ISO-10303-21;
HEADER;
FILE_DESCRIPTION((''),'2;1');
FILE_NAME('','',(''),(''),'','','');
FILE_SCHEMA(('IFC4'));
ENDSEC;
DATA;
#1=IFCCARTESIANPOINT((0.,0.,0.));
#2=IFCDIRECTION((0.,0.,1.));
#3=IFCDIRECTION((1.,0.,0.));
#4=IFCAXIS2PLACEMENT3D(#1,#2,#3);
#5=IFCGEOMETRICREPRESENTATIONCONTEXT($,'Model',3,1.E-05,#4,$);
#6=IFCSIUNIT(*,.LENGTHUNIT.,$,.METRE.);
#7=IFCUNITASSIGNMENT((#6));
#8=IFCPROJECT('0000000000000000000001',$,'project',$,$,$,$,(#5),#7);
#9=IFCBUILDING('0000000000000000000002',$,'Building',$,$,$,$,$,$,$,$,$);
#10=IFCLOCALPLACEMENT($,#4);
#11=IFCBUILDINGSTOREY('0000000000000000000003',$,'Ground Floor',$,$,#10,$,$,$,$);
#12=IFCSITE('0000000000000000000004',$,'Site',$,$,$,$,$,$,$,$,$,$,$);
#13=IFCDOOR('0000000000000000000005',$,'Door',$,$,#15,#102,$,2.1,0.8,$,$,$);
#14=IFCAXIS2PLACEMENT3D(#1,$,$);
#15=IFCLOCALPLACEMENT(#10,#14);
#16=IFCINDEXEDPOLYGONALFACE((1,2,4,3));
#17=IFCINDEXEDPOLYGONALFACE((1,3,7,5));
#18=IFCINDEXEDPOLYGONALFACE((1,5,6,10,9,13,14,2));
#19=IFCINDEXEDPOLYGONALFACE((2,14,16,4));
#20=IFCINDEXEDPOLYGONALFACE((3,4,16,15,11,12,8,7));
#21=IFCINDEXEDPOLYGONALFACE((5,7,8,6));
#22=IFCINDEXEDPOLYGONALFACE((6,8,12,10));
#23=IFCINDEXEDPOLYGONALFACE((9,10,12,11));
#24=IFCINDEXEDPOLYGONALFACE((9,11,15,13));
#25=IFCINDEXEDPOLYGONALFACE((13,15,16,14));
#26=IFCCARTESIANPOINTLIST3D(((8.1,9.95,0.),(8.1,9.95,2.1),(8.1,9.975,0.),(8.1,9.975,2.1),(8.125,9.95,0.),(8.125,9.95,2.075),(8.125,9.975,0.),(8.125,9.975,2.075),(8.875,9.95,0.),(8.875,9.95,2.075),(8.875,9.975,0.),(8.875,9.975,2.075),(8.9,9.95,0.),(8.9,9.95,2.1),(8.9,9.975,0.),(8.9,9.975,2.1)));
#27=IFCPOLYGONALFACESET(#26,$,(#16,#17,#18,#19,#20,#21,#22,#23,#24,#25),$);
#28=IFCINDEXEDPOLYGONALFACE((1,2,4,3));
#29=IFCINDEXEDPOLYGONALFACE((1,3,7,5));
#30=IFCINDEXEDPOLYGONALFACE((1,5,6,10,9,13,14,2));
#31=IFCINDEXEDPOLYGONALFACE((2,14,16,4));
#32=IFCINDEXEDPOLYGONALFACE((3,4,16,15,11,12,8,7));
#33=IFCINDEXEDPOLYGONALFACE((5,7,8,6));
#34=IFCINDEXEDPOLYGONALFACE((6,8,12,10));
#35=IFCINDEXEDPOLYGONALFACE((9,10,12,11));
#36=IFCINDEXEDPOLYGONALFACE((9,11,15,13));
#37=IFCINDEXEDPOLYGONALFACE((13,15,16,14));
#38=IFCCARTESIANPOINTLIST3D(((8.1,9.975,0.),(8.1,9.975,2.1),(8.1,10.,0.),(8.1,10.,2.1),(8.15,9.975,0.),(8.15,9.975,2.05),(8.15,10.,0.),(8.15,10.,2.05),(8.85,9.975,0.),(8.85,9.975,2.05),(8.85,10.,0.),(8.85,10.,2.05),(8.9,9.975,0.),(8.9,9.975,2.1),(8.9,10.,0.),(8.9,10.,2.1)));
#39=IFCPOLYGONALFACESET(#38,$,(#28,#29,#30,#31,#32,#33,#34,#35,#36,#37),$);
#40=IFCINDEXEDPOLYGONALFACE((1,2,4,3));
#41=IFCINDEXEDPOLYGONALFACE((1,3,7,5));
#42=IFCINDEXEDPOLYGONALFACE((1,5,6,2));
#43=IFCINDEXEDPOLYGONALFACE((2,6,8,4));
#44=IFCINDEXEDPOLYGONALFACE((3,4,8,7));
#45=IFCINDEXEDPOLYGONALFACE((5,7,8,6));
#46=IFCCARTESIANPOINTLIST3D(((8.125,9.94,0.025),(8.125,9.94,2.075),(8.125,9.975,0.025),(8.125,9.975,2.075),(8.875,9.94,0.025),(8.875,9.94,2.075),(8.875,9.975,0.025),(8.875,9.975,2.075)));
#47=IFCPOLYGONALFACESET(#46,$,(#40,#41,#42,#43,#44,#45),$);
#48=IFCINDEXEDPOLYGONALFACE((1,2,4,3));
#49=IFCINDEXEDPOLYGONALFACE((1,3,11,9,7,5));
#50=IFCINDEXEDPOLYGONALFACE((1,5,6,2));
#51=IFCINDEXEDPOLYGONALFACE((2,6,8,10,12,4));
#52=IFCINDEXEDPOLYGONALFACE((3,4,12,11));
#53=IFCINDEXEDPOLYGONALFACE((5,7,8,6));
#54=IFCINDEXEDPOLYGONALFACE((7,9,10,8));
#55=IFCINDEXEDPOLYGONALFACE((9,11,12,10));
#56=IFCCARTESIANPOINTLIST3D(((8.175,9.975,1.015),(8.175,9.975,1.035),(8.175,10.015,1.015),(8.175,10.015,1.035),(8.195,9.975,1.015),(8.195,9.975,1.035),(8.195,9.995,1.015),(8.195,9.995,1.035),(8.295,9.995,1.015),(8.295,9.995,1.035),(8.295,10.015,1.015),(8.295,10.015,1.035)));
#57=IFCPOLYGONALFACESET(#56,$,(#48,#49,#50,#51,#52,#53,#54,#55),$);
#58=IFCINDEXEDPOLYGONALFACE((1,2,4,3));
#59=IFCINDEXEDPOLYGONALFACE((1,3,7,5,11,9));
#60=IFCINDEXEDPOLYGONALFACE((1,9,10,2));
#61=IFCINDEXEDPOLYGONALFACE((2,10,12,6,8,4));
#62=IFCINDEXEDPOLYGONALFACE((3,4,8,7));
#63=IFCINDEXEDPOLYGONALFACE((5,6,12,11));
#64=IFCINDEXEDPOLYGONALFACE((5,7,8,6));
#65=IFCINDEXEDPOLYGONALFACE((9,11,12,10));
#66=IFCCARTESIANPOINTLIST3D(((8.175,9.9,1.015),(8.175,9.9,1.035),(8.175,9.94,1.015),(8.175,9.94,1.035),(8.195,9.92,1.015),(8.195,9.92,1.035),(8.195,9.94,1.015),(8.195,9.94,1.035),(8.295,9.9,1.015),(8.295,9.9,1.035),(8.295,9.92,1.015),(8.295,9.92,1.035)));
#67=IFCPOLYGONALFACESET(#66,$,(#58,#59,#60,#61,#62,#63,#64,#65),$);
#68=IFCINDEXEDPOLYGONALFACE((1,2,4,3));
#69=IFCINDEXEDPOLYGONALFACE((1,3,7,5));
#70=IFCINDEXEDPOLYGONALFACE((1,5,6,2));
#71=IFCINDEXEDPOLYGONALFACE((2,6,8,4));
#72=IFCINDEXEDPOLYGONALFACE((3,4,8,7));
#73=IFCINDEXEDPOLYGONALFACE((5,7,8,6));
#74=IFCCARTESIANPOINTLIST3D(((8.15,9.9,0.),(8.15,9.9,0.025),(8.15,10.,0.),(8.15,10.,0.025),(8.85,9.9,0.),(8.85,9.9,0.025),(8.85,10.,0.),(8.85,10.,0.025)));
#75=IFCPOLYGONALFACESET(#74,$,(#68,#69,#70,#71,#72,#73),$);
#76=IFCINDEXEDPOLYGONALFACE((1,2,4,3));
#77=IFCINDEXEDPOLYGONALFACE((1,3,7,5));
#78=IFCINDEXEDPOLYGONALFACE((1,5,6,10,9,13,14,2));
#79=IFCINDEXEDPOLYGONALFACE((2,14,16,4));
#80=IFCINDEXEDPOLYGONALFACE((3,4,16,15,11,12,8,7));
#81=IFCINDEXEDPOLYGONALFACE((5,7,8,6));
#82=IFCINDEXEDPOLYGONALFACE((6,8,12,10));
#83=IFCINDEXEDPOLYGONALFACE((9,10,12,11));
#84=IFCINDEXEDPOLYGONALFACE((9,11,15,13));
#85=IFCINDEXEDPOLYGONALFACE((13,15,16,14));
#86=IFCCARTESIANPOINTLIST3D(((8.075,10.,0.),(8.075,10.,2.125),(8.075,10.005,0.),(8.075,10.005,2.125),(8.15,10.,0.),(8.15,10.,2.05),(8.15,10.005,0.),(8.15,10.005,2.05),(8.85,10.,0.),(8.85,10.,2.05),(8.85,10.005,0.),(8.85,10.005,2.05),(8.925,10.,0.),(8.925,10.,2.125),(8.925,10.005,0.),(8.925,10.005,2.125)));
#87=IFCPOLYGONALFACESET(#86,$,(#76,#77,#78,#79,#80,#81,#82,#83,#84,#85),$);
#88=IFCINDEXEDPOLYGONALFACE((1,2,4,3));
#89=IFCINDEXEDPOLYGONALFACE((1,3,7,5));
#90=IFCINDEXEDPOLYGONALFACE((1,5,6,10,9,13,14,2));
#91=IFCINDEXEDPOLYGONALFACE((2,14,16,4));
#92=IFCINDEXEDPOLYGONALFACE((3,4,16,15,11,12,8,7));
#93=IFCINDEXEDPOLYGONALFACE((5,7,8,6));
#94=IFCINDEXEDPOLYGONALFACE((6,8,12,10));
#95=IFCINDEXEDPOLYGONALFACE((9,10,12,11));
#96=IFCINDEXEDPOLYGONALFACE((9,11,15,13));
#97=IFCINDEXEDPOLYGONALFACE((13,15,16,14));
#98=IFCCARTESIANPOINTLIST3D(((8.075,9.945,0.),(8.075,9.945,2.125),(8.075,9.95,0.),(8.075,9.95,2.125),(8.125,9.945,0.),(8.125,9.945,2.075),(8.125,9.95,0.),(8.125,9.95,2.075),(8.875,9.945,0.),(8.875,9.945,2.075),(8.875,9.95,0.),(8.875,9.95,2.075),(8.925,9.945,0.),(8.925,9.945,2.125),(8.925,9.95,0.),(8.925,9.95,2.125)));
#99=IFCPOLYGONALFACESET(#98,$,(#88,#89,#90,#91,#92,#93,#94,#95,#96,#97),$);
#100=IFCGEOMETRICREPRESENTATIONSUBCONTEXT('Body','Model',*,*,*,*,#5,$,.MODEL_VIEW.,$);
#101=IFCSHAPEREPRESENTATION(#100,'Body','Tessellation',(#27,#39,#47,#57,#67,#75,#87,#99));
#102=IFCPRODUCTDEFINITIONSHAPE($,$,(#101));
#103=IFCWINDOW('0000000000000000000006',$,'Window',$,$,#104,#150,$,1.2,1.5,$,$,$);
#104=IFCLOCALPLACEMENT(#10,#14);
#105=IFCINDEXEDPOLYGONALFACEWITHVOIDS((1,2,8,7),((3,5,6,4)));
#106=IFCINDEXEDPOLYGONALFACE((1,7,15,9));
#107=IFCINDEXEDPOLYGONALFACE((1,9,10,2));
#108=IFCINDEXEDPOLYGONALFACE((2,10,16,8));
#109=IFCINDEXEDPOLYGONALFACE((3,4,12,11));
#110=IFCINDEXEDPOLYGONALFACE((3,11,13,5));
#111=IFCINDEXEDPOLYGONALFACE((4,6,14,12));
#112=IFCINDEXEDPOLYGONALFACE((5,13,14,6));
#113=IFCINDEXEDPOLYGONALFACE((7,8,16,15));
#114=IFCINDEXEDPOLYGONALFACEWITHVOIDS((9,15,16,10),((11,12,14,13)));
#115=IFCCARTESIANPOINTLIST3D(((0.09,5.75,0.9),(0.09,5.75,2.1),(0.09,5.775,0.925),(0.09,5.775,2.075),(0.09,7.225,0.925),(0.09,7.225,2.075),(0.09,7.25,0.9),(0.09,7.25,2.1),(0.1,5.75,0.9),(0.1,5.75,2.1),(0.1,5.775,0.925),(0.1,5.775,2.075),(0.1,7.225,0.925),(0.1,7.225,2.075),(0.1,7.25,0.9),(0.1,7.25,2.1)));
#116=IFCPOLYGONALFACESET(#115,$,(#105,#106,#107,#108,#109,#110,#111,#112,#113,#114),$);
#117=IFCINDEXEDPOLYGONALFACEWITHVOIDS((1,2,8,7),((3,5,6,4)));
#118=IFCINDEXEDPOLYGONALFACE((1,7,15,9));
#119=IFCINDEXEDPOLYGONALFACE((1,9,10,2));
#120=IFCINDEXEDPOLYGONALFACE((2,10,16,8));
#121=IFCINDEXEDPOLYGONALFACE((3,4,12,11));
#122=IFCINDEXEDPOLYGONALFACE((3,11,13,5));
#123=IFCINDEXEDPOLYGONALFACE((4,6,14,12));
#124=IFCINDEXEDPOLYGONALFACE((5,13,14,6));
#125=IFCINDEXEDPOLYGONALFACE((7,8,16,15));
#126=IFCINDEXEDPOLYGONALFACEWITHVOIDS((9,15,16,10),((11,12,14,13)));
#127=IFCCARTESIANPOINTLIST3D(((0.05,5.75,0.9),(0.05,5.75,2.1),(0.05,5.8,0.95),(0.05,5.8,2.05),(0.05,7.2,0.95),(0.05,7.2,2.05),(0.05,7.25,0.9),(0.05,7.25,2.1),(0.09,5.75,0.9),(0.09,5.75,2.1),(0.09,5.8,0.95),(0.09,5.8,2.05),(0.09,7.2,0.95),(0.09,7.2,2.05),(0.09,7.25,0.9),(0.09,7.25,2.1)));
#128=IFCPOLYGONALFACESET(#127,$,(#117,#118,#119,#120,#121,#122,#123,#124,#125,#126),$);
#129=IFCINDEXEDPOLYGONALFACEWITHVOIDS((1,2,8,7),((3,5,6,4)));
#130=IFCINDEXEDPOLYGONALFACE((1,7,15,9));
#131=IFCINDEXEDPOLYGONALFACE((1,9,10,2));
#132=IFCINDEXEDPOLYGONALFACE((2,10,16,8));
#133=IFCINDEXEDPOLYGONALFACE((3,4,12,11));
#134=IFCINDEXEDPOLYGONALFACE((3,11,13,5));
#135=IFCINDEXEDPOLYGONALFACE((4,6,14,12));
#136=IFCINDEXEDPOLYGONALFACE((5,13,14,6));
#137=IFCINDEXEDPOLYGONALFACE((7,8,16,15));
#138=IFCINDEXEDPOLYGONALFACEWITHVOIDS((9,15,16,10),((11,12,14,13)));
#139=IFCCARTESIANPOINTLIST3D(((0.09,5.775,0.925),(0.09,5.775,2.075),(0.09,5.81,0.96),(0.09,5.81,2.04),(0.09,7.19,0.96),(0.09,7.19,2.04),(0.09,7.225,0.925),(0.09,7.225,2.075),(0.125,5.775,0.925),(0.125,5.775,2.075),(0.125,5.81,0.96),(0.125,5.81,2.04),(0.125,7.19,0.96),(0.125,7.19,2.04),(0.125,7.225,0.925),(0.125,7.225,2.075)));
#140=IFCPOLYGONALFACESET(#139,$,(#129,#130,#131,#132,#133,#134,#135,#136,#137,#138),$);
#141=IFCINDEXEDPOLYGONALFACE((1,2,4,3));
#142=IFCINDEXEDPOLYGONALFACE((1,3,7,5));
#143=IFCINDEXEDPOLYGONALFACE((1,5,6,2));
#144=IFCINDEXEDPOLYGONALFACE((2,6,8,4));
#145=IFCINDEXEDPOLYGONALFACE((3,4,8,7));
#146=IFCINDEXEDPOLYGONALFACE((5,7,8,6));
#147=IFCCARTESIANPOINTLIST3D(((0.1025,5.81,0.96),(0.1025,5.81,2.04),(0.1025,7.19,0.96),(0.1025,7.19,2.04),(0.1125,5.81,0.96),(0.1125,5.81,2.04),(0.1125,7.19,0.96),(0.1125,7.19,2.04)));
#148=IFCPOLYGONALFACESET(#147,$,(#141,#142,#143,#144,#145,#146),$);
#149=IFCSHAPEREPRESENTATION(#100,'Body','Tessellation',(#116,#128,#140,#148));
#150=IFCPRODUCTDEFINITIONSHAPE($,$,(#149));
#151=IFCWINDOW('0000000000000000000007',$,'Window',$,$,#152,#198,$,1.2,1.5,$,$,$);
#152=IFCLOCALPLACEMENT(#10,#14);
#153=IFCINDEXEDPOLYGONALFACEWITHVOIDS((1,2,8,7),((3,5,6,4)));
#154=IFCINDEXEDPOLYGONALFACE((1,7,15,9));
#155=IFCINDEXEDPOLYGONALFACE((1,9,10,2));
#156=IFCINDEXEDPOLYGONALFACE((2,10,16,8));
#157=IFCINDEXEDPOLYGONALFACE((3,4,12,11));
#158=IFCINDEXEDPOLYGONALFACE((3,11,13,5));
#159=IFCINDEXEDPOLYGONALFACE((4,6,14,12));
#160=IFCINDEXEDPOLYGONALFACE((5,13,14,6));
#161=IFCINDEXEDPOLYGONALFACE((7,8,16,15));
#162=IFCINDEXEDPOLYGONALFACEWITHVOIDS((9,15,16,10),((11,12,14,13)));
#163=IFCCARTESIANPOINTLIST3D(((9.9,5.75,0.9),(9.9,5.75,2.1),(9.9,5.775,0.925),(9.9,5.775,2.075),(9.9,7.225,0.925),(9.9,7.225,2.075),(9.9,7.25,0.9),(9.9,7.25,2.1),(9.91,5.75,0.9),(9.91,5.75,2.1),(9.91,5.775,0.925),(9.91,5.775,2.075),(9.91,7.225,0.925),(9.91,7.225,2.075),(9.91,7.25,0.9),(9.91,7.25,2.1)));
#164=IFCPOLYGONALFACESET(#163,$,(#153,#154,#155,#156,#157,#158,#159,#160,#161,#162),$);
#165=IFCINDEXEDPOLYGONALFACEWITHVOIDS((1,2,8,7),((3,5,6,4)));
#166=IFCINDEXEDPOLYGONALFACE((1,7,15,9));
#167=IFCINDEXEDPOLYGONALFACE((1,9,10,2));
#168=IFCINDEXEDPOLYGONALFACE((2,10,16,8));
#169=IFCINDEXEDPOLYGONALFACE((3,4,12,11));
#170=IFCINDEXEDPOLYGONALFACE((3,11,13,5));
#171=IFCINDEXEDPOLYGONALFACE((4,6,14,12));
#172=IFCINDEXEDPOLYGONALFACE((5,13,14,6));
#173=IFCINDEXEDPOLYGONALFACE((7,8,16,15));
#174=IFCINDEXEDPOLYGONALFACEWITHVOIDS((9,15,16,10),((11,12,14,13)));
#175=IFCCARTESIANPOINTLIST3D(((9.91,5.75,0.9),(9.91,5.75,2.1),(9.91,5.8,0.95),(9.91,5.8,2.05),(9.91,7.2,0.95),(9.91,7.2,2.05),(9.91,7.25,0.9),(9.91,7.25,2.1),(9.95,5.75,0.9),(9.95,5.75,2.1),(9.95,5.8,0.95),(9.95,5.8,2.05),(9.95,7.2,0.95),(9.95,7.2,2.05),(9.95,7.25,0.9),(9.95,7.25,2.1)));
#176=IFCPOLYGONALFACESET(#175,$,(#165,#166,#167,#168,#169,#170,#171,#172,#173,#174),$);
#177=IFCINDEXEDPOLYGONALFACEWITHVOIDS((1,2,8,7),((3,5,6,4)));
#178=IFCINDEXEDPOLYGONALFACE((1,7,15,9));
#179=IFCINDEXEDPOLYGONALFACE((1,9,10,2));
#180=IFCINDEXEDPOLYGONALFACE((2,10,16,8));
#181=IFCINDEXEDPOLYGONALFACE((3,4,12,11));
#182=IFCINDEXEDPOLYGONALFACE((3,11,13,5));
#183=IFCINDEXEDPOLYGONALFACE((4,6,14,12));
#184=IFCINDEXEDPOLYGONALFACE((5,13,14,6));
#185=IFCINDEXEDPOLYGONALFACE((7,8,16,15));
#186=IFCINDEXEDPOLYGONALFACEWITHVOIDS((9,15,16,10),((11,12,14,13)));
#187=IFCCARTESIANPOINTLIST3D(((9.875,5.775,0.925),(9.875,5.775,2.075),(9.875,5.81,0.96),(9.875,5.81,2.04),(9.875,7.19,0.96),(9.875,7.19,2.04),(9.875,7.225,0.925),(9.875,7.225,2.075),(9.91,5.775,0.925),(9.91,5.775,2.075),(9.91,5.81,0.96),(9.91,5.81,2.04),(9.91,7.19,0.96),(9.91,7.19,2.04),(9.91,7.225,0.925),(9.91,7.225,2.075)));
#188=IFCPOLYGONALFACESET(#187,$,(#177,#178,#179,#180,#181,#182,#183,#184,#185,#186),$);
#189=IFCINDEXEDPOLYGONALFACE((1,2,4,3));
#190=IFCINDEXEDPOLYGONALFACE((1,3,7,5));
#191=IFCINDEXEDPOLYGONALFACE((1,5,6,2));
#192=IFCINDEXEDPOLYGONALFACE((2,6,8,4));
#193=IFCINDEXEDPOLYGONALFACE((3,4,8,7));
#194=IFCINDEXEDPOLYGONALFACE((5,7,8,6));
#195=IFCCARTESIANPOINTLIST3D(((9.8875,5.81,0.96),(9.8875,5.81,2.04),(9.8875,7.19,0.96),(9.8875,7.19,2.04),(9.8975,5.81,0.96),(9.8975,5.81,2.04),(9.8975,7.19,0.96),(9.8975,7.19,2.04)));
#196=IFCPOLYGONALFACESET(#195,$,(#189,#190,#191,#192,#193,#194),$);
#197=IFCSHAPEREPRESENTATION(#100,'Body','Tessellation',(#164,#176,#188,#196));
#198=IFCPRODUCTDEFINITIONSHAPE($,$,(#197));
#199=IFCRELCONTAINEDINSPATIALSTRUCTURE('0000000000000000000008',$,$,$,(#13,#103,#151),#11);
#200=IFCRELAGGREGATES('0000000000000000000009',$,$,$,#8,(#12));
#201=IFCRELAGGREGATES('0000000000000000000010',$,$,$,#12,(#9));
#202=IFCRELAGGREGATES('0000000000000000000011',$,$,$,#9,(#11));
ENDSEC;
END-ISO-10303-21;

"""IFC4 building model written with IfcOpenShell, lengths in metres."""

from ifc_helpers import new_model, si_unit, frame, origin_with_axes, place, context, subcontext, project, spatial, line, indexed_curve, outline, extrude, element, save


model = new_model("IFC4")

# Units and contexts
model_context = context("Model", 3, precision=1e-05, world=origin_with_axes())
body_context = subcontext(model_context, "Body", "Model", "MODEL_VIEW")
ifc_project = project(units=[si_unit("LENGTHUNIT", "METRE")], contexts=[model_context])

# Site, building, storey
site = spatial("IfcSite", under=ifc_project, Name="Site")
building = spatial("IfcBuilding", under=site, Name="Building")
storey_placement = place(None, origin_with_axes())
storey = spatial("IfcBuildingStorey", under=building, at=storey_placement, Name="Ground Floor")

# Door
door_1_placement = place(storey_placement, frame((8.9, 10.0, 0.0), z_axis=(0.0, 0.0, 1.0), x_axis=(-1.0, 0.0, 0.0)))
element("IfcDoor", 1, at=door_1_placement, inside=storey, Name="Door", OverallHeight=2.1, OverallWidth=0.8, context=body_context, shape_type="SweptSolid", body=[
    extrude(outline(indexed_curve([(0.0, 0.0), (0.0, 2.1), (0.8, 2.1), (0.8, 0.0), (0.775, 0.0), (0.775, 2.075), (0.025, 2.075), (0.025, 0.0)], segments=[line(1, 2, 3, 4, 5, 6, 7, 8, 1)])), frame((0.0, 0.025, 0.0), z_axis=(0.0, -1.0, 0.0), x_axis=(1.0, 0.0, 0.0)), (0.0, 0.0, -1.0), 0.025),
    extrude(outline(indexed_curve([(0.0, 0.0), (0.0, 2.1), (0.8, 2.1), (0.8, 0.0), (0.75, 0.0), (0.75, 2.05), (0.05, 2.05), (0.05, 0.0)], segments=[line(1, 2, 3, 4, 5, 6, 7, 8, 1)])), frame((0.0, 0.0, 0.0), z_axis=(0.0, -1.0, 0.0), x_axis=(1.0, 0.0, 0.0)), (0.0, 0.0, -1.0), 0.025),
    extrude(outline(indexed_curve([(0.0, 0.0), (0.75, 0.0), (0.75, 0.035), (0.0, 0.035)], segments=[line(1, 2, 3, 4, 1)])), frame((0.025, 0.025, 0.025), z_axis=(0.0, 0.0, 1.0), x_axis=(1.0, 0.0, 0.0)), (0.0, 0.0, 1.0), 2.05),
    extrude(outline(indexed_curve([(0.0, 0.0), (0.0, -0.04), (-0.12, -0.04), (-0.12, -0.02), (-0.02, -0.02), (-0.02, 0.0)], segments=[line(1, 2, 3, 4, 5, 6, 1)])), frame((0.725, 0.025, 1.015), z_axis=(0.0, 0.0, 1.0), x_axis=(1.0, 0.0, 0.0)), (0.0, 0.0, 1.0), 0.02),
    extrude(outline(indexed_curve([(0.0, 0.0), (0.0, 0.04), (-0.12, 0.04), (-0.12, 0.02), (-0.02, 0.02), (-0.02, 0.0)], segments=[line(1, 2, 3, 4, 5, 6, 1)])), frame((0.725, 0.06, 1.015), z_axis=(0.0, 0.0, 1.0), x_axis=(1.0, 0.0, 0.0)), (0.0, 0.0, 1.0), 0.02),
    extrude(outline(indexed_curve([(0.0, 0.0), (0.7, 0.0), (0.7, 0.1), (0.0, 0.1)], segments=[line(1, 2, 3, 4, 1)])), frame((0.05, 0.0, 0.0), z_axis=(0.0, 0.0, 1.0), x_axis=(1.0, 0.0, 0.0)), (0.0, 0.0, 1.0), 0.025),
    extrude(outline(indexed_curve([(0.0, 0.0), (0.0, 2.125), (0.85, 2.125), (0.85, 0.0), (0.775, 0.0), (0.775, 2.05), (0.075, 2.05), (0.075, 0.0)], segments=[line(1, 2, 3, 4, 5, 6, 7, 8, 1)])), frame((-0.025, -0.005, 0.0), z_axis=(0.0, -1.0, 0.0), x_axis=(1.0, 0.0, 0.0)), (0.0, 0.0, -1.0), 0.005),
    extrude(outline(indexed_curve([(0.0, 0.0), (0.0, 2.125), (0.85, 2.125), (0.85, 0.0), (0.8, 0.0), (0.8, 2.075), (0.05, 2.075), (0.05, 0.0)], segments=[line(1, 2, 3, 4, 5, 6, 7, 8, 1)])), frame((-0.025, 0.05, 0.0), z_axis=(0.0, -1.0, 0.0), x_axis=(1.0, 0.0, 0.0)), (0.0, 0.0, -1.0), 0.005),
])

# Windows
for number, where, z_axis, x_axis, name in (
    (2, (0.0, 7.25, 0.9), (0.0, 0.0, 1.0), (0.0, -1.0, 0.0), "Window"),
    (3, (10.0, 5.75, 0.9), (0.0, 0.0, 1.0), (0.0, 1.0, 0.0), "Window"),
):
    element("IfcWindow", number, at=place(storey_placement, frame(where, z_axis=z_axis, x_axis=x_axis)), inside=storey, Name=name, OverallHeight=1.2, OverallWidth=1.5, context=body_context, shape_type="SweptSolid", body=[
        extrude(outline(indexed_curve([(0.0, 0.0), (1.5, 0.0), (1.5, 1.2), (0.0, 1.2)], segments=[line(1, 2, 3, 4, 1)]), holes=[indexed_curve([(0.025, 0.025), (1.475, 0.025), (1.475, 1.175), (0.025, 1.175)], segments=[line(1, 2, 3, 4, 1)])]), frame((0.0, 0.09, 0.0), z_axis=(0.0, -1.0, 0.0), x_axis=(1.0, 0.0, 0.0)), (0.0, 0.0, -1.0), 0.01),
        extrude(outline(indexed_curve([(0.0, 0.0), (1.5, 0.0), (1.5, 1.2), (0.0, 1.2)], segments=[line(1, 2, 3, 4, 1)]), holes=[indexed_curve([(0.05, 0.05), (1.45, 0.05), (1.45, 1.15), (0.05, 1.15)], segments=[line(1, 2, 3, 4, 1)])]), frame((0.0, 0.05, 0.0), z_axis=(0.0, -1.0, 0.0), x_axis=(1.0, 0.0, 0.0)), (0.0, 0.0, -1.0), 0.04),
        extrude(outline(indexed_curve([(0.0, 0.0), (1.45, 0.0), (1.45, 1.15), (0.0, 1.15)], segments=[line(1, 2, 3, 4, 1)]), holes=[indexed_curve([(0.035, 0.035), (1.415, 0.035), (1.415, 1.115), (0.035, 1.115)], segments=[line(1, 2, 3, 4, 1)])]), frame((0.025, 0.09, 0.025), z_axis=(0.0, -1.0, 0.0), x_axis=(1.0, 0.0, 0.0)), (0.0, 0.0, -1.0), 0.035),
        extrude(outline(indexed_curve([(0.035, 0.035), (1.415, 0.035), (1.415, 1.115), (0.035, 1.115)], segments=[line(1, 2, 3, 4, 1)])), frame((0.025, 0.1025, 0.025), z_axis=(0.0, -1.0, 0.0), x_axis=(1.0, 0.0, 0.0)), (0.0, 0.0, -1.0), 0.01),
    ])

save(model, "model.ifc")
